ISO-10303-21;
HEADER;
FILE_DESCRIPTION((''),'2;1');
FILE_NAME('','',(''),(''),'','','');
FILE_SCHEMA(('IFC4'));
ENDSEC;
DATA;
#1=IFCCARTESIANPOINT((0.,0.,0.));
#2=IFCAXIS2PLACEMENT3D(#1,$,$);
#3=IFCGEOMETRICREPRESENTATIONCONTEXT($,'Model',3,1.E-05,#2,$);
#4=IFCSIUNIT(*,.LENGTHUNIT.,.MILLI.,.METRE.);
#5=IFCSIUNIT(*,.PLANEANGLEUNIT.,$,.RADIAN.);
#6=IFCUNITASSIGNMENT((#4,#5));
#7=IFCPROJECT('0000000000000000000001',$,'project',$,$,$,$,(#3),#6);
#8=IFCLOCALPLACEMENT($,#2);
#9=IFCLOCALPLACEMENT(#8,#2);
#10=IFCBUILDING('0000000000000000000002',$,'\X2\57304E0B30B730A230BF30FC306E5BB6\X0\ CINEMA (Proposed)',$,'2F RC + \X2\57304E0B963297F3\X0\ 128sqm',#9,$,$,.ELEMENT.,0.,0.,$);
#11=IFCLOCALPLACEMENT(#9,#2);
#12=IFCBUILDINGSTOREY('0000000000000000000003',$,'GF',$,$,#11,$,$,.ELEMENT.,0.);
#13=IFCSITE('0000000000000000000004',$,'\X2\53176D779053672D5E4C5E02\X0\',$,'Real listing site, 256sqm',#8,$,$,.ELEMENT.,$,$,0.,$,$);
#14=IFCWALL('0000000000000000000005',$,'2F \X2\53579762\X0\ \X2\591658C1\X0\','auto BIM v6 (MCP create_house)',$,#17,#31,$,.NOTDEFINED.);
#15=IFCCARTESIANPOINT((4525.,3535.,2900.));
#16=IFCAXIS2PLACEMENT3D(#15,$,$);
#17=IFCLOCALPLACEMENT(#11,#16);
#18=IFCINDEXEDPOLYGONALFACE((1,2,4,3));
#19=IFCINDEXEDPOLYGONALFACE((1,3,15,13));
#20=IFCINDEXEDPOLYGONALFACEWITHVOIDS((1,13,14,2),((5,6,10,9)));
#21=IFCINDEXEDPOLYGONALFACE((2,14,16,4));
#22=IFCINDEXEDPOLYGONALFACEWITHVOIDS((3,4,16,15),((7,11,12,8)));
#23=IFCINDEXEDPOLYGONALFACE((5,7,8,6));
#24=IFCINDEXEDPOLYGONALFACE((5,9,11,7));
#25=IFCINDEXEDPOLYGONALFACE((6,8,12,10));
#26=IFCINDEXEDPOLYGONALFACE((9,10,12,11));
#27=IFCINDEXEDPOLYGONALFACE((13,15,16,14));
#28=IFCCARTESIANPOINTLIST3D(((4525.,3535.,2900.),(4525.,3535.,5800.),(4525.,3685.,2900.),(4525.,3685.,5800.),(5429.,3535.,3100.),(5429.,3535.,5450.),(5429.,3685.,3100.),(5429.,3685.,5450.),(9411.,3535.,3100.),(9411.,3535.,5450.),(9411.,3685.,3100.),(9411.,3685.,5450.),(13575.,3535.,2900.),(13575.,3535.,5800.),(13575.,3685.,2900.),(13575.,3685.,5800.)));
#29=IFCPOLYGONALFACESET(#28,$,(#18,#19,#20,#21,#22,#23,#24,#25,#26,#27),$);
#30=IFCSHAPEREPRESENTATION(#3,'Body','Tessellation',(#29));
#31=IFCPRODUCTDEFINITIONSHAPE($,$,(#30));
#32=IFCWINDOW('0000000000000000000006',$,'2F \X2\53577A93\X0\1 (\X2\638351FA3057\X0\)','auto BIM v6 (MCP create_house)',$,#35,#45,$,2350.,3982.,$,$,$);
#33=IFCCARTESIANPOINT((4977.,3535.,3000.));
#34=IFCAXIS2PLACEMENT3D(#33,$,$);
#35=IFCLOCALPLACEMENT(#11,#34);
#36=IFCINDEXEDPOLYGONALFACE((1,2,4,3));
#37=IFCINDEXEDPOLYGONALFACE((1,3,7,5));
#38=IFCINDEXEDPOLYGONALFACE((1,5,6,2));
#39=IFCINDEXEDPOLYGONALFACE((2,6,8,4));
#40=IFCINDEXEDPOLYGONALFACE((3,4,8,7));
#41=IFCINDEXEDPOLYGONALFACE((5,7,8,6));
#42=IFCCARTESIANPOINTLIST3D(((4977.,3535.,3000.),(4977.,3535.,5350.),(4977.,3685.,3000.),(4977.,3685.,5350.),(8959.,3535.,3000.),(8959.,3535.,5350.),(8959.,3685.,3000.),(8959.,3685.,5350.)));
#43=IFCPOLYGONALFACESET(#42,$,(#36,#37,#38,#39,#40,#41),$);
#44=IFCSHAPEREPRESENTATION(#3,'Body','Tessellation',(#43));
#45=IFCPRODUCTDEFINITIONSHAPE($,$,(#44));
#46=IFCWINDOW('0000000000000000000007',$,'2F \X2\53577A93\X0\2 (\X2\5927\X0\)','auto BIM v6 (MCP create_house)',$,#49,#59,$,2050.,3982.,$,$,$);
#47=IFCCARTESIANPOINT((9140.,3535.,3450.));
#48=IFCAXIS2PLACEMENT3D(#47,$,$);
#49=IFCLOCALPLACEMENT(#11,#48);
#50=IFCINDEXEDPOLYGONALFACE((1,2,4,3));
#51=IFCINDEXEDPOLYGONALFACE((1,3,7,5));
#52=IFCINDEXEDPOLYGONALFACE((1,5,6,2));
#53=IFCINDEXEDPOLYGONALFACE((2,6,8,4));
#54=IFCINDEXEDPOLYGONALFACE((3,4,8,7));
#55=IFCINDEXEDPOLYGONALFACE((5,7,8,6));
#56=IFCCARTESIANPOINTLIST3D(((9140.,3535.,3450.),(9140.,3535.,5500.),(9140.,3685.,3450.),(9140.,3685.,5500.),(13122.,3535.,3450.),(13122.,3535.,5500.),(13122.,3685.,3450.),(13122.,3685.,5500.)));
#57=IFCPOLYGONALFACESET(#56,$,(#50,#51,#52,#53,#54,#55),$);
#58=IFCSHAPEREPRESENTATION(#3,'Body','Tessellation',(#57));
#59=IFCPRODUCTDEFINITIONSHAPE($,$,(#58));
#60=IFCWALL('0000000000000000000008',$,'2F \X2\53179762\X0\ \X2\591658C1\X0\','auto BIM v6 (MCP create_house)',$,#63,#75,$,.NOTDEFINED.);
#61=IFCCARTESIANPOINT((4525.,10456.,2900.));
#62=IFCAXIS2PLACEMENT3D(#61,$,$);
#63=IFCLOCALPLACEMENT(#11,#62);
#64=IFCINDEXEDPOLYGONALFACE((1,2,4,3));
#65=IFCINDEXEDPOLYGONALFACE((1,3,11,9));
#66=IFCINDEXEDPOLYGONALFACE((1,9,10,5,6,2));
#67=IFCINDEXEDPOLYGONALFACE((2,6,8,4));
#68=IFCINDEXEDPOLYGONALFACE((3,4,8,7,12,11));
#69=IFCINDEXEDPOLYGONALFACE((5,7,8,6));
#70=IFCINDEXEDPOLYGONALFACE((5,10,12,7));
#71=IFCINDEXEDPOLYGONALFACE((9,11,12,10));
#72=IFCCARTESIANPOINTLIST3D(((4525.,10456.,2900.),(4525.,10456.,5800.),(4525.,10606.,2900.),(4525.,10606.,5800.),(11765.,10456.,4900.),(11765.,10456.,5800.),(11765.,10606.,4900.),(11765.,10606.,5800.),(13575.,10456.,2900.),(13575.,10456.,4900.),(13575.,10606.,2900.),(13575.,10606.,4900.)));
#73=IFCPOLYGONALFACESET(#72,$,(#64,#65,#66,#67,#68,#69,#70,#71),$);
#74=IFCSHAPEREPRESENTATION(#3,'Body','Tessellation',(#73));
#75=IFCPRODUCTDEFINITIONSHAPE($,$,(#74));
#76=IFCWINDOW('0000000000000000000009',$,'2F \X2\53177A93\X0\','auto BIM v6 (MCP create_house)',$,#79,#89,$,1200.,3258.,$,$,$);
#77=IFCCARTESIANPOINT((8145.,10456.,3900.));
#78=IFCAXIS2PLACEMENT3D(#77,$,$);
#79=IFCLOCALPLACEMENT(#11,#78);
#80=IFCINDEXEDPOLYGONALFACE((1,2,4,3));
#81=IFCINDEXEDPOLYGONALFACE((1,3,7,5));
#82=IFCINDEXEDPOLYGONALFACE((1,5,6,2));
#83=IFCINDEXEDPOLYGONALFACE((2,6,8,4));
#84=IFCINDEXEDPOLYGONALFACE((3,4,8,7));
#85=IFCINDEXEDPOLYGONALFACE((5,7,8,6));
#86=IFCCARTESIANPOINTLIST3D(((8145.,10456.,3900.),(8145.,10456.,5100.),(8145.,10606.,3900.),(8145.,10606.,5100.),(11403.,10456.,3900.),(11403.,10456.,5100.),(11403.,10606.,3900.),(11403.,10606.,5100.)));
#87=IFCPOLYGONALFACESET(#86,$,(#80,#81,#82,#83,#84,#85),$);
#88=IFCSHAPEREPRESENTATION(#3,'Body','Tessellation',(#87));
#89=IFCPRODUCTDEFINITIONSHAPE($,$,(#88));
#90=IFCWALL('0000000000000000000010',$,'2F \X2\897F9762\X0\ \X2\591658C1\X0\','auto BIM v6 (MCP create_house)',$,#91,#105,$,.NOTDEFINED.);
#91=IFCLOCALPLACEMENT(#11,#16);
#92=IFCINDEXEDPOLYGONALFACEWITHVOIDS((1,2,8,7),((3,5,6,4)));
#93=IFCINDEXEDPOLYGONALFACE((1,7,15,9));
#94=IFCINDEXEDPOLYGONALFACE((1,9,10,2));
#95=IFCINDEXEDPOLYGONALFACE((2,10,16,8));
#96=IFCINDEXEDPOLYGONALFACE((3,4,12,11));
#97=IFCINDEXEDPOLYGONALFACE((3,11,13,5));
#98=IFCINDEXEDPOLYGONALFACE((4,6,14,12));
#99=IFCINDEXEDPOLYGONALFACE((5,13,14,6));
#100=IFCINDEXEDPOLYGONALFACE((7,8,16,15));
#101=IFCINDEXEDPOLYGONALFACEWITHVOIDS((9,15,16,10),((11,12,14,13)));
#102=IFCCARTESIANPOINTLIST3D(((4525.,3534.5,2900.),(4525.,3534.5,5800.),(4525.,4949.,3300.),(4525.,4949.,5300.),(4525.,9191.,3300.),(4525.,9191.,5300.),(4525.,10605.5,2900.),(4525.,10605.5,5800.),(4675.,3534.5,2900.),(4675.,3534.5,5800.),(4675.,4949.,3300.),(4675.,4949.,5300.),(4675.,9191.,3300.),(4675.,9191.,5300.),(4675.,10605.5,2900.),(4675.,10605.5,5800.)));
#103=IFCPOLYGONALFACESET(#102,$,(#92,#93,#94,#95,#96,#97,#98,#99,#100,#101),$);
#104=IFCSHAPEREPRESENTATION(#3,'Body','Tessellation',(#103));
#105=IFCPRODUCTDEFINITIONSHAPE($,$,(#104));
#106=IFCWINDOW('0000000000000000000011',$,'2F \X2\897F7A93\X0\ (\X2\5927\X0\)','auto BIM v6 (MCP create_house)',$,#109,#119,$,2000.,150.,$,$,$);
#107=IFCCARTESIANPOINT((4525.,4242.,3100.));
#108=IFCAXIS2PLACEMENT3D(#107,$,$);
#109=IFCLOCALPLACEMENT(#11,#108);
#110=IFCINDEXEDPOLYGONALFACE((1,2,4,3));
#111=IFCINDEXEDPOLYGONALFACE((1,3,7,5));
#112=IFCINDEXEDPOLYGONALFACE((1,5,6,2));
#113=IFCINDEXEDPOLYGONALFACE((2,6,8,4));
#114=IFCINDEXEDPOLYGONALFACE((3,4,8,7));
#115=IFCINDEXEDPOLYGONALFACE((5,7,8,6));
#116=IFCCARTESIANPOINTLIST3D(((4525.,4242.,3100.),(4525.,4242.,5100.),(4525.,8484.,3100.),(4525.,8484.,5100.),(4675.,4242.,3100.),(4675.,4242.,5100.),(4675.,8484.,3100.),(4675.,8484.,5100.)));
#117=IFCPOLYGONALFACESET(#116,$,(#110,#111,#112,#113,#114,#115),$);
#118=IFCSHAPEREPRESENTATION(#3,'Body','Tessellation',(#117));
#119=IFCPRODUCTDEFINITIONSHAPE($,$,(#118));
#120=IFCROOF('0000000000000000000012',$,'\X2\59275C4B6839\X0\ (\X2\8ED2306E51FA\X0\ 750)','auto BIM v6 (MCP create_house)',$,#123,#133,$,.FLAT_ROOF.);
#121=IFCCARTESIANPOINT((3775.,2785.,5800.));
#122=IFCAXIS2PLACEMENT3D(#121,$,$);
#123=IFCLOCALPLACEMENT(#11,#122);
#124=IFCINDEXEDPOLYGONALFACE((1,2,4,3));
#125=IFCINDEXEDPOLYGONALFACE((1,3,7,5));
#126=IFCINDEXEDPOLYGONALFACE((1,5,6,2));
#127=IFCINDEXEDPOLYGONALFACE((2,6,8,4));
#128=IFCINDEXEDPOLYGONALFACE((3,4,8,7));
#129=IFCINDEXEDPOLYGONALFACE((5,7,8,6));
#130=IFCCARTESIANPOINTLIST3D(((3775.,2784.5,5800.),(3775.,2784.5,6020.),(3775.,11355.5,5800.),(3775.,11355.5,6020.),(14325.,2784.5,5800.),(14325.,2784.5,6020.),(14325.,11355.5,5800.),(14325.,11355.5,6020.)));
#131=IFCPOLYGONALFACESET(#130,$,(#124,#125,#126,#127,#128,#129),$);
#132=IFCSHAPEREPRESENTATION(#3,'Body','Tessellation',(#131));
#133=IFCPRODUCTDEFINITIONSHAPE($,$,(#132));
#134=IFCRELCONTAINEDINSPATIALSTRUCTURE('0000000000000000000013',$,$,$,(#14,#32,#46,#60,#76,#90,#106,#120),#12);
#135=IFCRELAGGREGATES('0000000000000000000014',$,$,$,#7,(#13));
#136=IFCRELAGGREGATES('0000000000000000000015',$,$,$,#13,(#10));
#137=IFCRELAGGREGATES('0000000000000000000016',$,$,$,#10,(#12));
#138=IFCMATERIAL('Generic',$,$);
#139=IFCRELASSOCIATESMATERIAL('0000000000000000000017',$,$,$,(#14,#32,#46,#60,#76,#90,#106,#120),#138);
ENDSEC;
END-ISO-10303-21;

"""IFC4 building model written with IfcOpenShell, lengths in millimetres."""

from ifc_helpers import new_model, si_unit, frame, frame_2d, origin, place, context, project, spatial, rectangle, extrude, material, element, fill, save


model = new_model("IFC4")

# Units and contexts
model_context = context("Model", 3, precision=1e-05, world=origin())
ifc_project = project(units=[si_unit("LENGTHUNIT", "METRE", prefix="MILLI"), si_unit("PLANEANGLEUNIT", "RADIAN")], contexts=[model_context])

# Site, building, storey
site_placement = place(None, origin())
site = spatial("IfcSite", under=ifc_project, at=site_placement, Name="北海道札幌市", ObjectType="Real listing site, 256sqm", CompositionType="ELEMENT", RefElevation=0.0)
building_placement = place(site_placement, origin())
building = spatial("IfcBuilding", under=site, at=building_placement, Name="地下シアターの家 CINEMA (Proposed)", ObjectType="2F RC + 地下防音 128sqm", CompositionType="ELEMENT", ElevationOfRefHeight=0.0, ElevationOfTerrain=0.0)
storey_placement = place(building_placement, origin())
storey = spatial("IfcBuildingStorey", under=building, at=storey_placement, Name="GF", CompositionType="ELEMENT", Elevation=0.0)

# Shared definitions
ifc_material = material(Name="Generic")

# Wall, openings, windows
wall_1_placement = place(storey_placement, frame((4525.0, 3535.0, 2900.0)))
wall_1 = element("IfcWall", 1, at=wall_1_placement, inside=storey, material=ifc_material, Name="2F 南面 外壁", Description="auto BIM v6 (MCP create_house)", PredefinedType="NOTDEFINED", context=model_context, shape_type="SweptSolid", body=[
    extrude(rectangle(XDim=9050.0, YDim=150.0, at=frame_2d((4525.0, 75.0))), frame((4525.0, 3535.0, 2900.0)), (0.0, 0.0, 1.0), 2900.0),
])
opening_1_placement = place(storey_placement, frame((4977.0, 3535.0, 3000.0)))
opening_1 = element("IfcOpeningElement", 2, at=opening_1_placement, cuts=wall_1, PredefinedType="NOTDEFINED", context=model_context, shape_type="SweptSolid", body=[
    extrude(rectangle(XDim=3982.0, YDim=150.0, at=frame_2d((1991.0, 75.0))), frame((4977.0, 3535.0, 3000.0)), (0.0, 0.0, 1.0), 2350.0),
])
opening_2_placement = place(storey_placement, frame((9140.0, 3535.0, 3450.0)))
opening_2 = element("IfcOpeningElement", 3, at=opening_2_placement, cuts=wall_1, PredefinedType="NOTDEFINED", context=model_context, shape_type="SweptSolid", body=[
    extrude(rectangle(XDim=3982.0, YDim=150.0, at=frame_2d((1991.0, 75.0))), frame((9140.0, 3535.0, 3450.0)), (0.0, 0.0, 1.0), 2050.0),
])
window_1_placement = place(storey_placement, frame((4977.0, 3535.0, 3000.0)))
window_1 = element("IfcWindow", 4, at=window_1_placement, inside=storey, material=ifc_material, Name="2F 南窓1 (掃出し)", Description="auto BIM v6 (MCP create_house)", OverallHeight=2350.0, OverallWidth=3982.0, context=model_context, shape_type="SweptSolid", body=[
    extrude(rectangle(XDim=3982.0, YDim=150.0, at=frame_2d((1991.0, 75.0))), frame((4977.0, 3535.0, 3000.0)), (0.0, 0.0, 1.0), 2350.0),
])
fill(opening_1, window_1)
window_2_placement = place(storey_placement, frame((9140.0, 3535.0, 3450.0)))
window_2 = element("IfcWindow", 5, at=window_2_placement, inside=storey, material=ifc_material, Name="2F 南窓2 (大)", Description="auto BIM v6 (MCP create_house)", OverallHeight=2050.0, OverallWidth=3982.0, context=model_context, shape_type="SweptSolid", body=[
    extrude(rectangle(XDim=3982.0, YDim=150.0, at=frame_2d((1991.0, 75.0))), frame((9140.0, 3535.0, 3450.0)), (0.0, 0.0, 1.0), 2050.0),
])
fill(opening_2, window_2)

# Walls, openings, windows
wall_2_placement = place(storey_placement, frame((4525.0, 10456.0, 2900.0)))
wall_2 = element("IfcWall", 6, at=wall_2_placement, inside=storey, material=ifc_material, Name="2F 北面 外壁", Description="auto BIM v6 (MCP create_house)", PredefinedType="NOTDEFINED", context=model_context, shape_type="SweptSolid", body=[
    extrude(rectangle(XDim=9050.0, YDim=150.0, at=frame_2d((4525.0, 75.0))), frame((4525.0, 10456.0, 2900.0)), (0.0, 0.0, 1.0), 2900.0),
])
opening_3_placement = place(storey_placement, frame((8145.0, 10456.0, 3900.0)))
opening_3 = element("IfcOpeningElement", 7, at=opening_3_placement, cuts=wall_2, PredefinedType="NOTDEFINED", context=model_context, shape_type="SweptSolid", body=[
    extrude(rectangle(XDim=3258.0, YDim=150.0, at=frame_2d((1629.0, 75.0))), frame((8145.0, 10456.0, 3900.0)), (0.0, 0.0, 1.0), 1200.0),
])
window_3_placement = place(storey_placement, frame((8145.0, 10456.0, 3900.0)))
window_3 = element("IfcWindow", 8, at=window_3_placement, inside=storey, material=ifc_material, Name="2F 北窓", Description="auto BIM v6 (MCP create_house)", OverallHeight=1200.0, OverallWidth=3258.0, context=model_context, shape_type="SweptSolid", body=[
    extrude(rectangle(XDim=3258.0, YDim=150.0, at=frame_2d((1629.0, 75.0))), frame((8145.0, 10456.0, 3900.0)), (0.0, 0.0, 1.0), 1200.0),
])
fill(opening_3, window_3)
wall_3_placement = place(storey_placement, frame((4525.0, 3535.0, 2900.0)))
wall_3 = element("IfcWall", 9, at=wall_3_placement, inside=storey, material=ifc_material, Name="2F 西面 外壁", Description="auto BIM v6 (MCP create_house)", PredefinedType="NOTDEFINED", context=model_context, shape_type="SweptSolid", body=[
    extrude(rectangle(XDim=150.0, YDim=7071.0, at=frame_2d((75.0, 3535.0))), frame((4525.0, 3535.0, 2900.0)), (0.0, 0.0, 1.0), 2900.0),
])
opening_4_placement = place(storey_placement, frame((4525.0, 4242.0, 3100.0)))
opening_4 = element("IfcOpeningElement", 10, at=opening_4_placement, cuts=wall_3, PredefinedType="NOTDEFINED", context=model_context, shape_type="SweptSolid", body=[
    extrude(rectangle(XDim=150.0, YDim=4242.0, at=frame_2d((75.0, 2121.0))), frame((4525.0, 4242.0, 3100.0)), (0.0, 0.0, 1.0), 2000.0),
])
window_4_placement = place(storey_placement, frame((4525.0, 4242.0, 3100.0)))
window_4 = element("IfcWindow", 11, at=window_4_placement, inside=storey, material=ifc_material, Name="2F 西窓 (大)", Description="auto BIM v6 (MCP create_house)", OverallHeight=2000.0, OverallWidth=150.0, context=model_context, shape_type="SweptSolid", body=[
    extrude(rectangle(XDim=150.0, YDim=4242.0, at=frame_2d((75.0, 2121.0))), frame((4525.0, 4242.0, 3100.0)), (0.0, 0.0, 1.0), 2000.0),
])
fill(opening_4, window_4)

# Roof
roof_placement = place(storey_placement, frame((3775.0, 2785.0, 5800.0)))
element("IfcRoof", 12, at=roof_placement, inside=storey, material=ifc_material, Name="大屋根 (軒の出 750)", Description="auto BIM v6 (MCP create_house)", PredefinedType="FLAT_ROOF", context=model_context, shape_type="SweptSolid", body=[
    extrude(rectangle(XDim=10550.0, YDim=8571.0, at=frame_2d((5275.0, 4285.0))), frame((3775.0, 2785.0, 5800.0)), (0.0, 0.0, 1.0), 220.0),
])

save(model, "model.ifc")
